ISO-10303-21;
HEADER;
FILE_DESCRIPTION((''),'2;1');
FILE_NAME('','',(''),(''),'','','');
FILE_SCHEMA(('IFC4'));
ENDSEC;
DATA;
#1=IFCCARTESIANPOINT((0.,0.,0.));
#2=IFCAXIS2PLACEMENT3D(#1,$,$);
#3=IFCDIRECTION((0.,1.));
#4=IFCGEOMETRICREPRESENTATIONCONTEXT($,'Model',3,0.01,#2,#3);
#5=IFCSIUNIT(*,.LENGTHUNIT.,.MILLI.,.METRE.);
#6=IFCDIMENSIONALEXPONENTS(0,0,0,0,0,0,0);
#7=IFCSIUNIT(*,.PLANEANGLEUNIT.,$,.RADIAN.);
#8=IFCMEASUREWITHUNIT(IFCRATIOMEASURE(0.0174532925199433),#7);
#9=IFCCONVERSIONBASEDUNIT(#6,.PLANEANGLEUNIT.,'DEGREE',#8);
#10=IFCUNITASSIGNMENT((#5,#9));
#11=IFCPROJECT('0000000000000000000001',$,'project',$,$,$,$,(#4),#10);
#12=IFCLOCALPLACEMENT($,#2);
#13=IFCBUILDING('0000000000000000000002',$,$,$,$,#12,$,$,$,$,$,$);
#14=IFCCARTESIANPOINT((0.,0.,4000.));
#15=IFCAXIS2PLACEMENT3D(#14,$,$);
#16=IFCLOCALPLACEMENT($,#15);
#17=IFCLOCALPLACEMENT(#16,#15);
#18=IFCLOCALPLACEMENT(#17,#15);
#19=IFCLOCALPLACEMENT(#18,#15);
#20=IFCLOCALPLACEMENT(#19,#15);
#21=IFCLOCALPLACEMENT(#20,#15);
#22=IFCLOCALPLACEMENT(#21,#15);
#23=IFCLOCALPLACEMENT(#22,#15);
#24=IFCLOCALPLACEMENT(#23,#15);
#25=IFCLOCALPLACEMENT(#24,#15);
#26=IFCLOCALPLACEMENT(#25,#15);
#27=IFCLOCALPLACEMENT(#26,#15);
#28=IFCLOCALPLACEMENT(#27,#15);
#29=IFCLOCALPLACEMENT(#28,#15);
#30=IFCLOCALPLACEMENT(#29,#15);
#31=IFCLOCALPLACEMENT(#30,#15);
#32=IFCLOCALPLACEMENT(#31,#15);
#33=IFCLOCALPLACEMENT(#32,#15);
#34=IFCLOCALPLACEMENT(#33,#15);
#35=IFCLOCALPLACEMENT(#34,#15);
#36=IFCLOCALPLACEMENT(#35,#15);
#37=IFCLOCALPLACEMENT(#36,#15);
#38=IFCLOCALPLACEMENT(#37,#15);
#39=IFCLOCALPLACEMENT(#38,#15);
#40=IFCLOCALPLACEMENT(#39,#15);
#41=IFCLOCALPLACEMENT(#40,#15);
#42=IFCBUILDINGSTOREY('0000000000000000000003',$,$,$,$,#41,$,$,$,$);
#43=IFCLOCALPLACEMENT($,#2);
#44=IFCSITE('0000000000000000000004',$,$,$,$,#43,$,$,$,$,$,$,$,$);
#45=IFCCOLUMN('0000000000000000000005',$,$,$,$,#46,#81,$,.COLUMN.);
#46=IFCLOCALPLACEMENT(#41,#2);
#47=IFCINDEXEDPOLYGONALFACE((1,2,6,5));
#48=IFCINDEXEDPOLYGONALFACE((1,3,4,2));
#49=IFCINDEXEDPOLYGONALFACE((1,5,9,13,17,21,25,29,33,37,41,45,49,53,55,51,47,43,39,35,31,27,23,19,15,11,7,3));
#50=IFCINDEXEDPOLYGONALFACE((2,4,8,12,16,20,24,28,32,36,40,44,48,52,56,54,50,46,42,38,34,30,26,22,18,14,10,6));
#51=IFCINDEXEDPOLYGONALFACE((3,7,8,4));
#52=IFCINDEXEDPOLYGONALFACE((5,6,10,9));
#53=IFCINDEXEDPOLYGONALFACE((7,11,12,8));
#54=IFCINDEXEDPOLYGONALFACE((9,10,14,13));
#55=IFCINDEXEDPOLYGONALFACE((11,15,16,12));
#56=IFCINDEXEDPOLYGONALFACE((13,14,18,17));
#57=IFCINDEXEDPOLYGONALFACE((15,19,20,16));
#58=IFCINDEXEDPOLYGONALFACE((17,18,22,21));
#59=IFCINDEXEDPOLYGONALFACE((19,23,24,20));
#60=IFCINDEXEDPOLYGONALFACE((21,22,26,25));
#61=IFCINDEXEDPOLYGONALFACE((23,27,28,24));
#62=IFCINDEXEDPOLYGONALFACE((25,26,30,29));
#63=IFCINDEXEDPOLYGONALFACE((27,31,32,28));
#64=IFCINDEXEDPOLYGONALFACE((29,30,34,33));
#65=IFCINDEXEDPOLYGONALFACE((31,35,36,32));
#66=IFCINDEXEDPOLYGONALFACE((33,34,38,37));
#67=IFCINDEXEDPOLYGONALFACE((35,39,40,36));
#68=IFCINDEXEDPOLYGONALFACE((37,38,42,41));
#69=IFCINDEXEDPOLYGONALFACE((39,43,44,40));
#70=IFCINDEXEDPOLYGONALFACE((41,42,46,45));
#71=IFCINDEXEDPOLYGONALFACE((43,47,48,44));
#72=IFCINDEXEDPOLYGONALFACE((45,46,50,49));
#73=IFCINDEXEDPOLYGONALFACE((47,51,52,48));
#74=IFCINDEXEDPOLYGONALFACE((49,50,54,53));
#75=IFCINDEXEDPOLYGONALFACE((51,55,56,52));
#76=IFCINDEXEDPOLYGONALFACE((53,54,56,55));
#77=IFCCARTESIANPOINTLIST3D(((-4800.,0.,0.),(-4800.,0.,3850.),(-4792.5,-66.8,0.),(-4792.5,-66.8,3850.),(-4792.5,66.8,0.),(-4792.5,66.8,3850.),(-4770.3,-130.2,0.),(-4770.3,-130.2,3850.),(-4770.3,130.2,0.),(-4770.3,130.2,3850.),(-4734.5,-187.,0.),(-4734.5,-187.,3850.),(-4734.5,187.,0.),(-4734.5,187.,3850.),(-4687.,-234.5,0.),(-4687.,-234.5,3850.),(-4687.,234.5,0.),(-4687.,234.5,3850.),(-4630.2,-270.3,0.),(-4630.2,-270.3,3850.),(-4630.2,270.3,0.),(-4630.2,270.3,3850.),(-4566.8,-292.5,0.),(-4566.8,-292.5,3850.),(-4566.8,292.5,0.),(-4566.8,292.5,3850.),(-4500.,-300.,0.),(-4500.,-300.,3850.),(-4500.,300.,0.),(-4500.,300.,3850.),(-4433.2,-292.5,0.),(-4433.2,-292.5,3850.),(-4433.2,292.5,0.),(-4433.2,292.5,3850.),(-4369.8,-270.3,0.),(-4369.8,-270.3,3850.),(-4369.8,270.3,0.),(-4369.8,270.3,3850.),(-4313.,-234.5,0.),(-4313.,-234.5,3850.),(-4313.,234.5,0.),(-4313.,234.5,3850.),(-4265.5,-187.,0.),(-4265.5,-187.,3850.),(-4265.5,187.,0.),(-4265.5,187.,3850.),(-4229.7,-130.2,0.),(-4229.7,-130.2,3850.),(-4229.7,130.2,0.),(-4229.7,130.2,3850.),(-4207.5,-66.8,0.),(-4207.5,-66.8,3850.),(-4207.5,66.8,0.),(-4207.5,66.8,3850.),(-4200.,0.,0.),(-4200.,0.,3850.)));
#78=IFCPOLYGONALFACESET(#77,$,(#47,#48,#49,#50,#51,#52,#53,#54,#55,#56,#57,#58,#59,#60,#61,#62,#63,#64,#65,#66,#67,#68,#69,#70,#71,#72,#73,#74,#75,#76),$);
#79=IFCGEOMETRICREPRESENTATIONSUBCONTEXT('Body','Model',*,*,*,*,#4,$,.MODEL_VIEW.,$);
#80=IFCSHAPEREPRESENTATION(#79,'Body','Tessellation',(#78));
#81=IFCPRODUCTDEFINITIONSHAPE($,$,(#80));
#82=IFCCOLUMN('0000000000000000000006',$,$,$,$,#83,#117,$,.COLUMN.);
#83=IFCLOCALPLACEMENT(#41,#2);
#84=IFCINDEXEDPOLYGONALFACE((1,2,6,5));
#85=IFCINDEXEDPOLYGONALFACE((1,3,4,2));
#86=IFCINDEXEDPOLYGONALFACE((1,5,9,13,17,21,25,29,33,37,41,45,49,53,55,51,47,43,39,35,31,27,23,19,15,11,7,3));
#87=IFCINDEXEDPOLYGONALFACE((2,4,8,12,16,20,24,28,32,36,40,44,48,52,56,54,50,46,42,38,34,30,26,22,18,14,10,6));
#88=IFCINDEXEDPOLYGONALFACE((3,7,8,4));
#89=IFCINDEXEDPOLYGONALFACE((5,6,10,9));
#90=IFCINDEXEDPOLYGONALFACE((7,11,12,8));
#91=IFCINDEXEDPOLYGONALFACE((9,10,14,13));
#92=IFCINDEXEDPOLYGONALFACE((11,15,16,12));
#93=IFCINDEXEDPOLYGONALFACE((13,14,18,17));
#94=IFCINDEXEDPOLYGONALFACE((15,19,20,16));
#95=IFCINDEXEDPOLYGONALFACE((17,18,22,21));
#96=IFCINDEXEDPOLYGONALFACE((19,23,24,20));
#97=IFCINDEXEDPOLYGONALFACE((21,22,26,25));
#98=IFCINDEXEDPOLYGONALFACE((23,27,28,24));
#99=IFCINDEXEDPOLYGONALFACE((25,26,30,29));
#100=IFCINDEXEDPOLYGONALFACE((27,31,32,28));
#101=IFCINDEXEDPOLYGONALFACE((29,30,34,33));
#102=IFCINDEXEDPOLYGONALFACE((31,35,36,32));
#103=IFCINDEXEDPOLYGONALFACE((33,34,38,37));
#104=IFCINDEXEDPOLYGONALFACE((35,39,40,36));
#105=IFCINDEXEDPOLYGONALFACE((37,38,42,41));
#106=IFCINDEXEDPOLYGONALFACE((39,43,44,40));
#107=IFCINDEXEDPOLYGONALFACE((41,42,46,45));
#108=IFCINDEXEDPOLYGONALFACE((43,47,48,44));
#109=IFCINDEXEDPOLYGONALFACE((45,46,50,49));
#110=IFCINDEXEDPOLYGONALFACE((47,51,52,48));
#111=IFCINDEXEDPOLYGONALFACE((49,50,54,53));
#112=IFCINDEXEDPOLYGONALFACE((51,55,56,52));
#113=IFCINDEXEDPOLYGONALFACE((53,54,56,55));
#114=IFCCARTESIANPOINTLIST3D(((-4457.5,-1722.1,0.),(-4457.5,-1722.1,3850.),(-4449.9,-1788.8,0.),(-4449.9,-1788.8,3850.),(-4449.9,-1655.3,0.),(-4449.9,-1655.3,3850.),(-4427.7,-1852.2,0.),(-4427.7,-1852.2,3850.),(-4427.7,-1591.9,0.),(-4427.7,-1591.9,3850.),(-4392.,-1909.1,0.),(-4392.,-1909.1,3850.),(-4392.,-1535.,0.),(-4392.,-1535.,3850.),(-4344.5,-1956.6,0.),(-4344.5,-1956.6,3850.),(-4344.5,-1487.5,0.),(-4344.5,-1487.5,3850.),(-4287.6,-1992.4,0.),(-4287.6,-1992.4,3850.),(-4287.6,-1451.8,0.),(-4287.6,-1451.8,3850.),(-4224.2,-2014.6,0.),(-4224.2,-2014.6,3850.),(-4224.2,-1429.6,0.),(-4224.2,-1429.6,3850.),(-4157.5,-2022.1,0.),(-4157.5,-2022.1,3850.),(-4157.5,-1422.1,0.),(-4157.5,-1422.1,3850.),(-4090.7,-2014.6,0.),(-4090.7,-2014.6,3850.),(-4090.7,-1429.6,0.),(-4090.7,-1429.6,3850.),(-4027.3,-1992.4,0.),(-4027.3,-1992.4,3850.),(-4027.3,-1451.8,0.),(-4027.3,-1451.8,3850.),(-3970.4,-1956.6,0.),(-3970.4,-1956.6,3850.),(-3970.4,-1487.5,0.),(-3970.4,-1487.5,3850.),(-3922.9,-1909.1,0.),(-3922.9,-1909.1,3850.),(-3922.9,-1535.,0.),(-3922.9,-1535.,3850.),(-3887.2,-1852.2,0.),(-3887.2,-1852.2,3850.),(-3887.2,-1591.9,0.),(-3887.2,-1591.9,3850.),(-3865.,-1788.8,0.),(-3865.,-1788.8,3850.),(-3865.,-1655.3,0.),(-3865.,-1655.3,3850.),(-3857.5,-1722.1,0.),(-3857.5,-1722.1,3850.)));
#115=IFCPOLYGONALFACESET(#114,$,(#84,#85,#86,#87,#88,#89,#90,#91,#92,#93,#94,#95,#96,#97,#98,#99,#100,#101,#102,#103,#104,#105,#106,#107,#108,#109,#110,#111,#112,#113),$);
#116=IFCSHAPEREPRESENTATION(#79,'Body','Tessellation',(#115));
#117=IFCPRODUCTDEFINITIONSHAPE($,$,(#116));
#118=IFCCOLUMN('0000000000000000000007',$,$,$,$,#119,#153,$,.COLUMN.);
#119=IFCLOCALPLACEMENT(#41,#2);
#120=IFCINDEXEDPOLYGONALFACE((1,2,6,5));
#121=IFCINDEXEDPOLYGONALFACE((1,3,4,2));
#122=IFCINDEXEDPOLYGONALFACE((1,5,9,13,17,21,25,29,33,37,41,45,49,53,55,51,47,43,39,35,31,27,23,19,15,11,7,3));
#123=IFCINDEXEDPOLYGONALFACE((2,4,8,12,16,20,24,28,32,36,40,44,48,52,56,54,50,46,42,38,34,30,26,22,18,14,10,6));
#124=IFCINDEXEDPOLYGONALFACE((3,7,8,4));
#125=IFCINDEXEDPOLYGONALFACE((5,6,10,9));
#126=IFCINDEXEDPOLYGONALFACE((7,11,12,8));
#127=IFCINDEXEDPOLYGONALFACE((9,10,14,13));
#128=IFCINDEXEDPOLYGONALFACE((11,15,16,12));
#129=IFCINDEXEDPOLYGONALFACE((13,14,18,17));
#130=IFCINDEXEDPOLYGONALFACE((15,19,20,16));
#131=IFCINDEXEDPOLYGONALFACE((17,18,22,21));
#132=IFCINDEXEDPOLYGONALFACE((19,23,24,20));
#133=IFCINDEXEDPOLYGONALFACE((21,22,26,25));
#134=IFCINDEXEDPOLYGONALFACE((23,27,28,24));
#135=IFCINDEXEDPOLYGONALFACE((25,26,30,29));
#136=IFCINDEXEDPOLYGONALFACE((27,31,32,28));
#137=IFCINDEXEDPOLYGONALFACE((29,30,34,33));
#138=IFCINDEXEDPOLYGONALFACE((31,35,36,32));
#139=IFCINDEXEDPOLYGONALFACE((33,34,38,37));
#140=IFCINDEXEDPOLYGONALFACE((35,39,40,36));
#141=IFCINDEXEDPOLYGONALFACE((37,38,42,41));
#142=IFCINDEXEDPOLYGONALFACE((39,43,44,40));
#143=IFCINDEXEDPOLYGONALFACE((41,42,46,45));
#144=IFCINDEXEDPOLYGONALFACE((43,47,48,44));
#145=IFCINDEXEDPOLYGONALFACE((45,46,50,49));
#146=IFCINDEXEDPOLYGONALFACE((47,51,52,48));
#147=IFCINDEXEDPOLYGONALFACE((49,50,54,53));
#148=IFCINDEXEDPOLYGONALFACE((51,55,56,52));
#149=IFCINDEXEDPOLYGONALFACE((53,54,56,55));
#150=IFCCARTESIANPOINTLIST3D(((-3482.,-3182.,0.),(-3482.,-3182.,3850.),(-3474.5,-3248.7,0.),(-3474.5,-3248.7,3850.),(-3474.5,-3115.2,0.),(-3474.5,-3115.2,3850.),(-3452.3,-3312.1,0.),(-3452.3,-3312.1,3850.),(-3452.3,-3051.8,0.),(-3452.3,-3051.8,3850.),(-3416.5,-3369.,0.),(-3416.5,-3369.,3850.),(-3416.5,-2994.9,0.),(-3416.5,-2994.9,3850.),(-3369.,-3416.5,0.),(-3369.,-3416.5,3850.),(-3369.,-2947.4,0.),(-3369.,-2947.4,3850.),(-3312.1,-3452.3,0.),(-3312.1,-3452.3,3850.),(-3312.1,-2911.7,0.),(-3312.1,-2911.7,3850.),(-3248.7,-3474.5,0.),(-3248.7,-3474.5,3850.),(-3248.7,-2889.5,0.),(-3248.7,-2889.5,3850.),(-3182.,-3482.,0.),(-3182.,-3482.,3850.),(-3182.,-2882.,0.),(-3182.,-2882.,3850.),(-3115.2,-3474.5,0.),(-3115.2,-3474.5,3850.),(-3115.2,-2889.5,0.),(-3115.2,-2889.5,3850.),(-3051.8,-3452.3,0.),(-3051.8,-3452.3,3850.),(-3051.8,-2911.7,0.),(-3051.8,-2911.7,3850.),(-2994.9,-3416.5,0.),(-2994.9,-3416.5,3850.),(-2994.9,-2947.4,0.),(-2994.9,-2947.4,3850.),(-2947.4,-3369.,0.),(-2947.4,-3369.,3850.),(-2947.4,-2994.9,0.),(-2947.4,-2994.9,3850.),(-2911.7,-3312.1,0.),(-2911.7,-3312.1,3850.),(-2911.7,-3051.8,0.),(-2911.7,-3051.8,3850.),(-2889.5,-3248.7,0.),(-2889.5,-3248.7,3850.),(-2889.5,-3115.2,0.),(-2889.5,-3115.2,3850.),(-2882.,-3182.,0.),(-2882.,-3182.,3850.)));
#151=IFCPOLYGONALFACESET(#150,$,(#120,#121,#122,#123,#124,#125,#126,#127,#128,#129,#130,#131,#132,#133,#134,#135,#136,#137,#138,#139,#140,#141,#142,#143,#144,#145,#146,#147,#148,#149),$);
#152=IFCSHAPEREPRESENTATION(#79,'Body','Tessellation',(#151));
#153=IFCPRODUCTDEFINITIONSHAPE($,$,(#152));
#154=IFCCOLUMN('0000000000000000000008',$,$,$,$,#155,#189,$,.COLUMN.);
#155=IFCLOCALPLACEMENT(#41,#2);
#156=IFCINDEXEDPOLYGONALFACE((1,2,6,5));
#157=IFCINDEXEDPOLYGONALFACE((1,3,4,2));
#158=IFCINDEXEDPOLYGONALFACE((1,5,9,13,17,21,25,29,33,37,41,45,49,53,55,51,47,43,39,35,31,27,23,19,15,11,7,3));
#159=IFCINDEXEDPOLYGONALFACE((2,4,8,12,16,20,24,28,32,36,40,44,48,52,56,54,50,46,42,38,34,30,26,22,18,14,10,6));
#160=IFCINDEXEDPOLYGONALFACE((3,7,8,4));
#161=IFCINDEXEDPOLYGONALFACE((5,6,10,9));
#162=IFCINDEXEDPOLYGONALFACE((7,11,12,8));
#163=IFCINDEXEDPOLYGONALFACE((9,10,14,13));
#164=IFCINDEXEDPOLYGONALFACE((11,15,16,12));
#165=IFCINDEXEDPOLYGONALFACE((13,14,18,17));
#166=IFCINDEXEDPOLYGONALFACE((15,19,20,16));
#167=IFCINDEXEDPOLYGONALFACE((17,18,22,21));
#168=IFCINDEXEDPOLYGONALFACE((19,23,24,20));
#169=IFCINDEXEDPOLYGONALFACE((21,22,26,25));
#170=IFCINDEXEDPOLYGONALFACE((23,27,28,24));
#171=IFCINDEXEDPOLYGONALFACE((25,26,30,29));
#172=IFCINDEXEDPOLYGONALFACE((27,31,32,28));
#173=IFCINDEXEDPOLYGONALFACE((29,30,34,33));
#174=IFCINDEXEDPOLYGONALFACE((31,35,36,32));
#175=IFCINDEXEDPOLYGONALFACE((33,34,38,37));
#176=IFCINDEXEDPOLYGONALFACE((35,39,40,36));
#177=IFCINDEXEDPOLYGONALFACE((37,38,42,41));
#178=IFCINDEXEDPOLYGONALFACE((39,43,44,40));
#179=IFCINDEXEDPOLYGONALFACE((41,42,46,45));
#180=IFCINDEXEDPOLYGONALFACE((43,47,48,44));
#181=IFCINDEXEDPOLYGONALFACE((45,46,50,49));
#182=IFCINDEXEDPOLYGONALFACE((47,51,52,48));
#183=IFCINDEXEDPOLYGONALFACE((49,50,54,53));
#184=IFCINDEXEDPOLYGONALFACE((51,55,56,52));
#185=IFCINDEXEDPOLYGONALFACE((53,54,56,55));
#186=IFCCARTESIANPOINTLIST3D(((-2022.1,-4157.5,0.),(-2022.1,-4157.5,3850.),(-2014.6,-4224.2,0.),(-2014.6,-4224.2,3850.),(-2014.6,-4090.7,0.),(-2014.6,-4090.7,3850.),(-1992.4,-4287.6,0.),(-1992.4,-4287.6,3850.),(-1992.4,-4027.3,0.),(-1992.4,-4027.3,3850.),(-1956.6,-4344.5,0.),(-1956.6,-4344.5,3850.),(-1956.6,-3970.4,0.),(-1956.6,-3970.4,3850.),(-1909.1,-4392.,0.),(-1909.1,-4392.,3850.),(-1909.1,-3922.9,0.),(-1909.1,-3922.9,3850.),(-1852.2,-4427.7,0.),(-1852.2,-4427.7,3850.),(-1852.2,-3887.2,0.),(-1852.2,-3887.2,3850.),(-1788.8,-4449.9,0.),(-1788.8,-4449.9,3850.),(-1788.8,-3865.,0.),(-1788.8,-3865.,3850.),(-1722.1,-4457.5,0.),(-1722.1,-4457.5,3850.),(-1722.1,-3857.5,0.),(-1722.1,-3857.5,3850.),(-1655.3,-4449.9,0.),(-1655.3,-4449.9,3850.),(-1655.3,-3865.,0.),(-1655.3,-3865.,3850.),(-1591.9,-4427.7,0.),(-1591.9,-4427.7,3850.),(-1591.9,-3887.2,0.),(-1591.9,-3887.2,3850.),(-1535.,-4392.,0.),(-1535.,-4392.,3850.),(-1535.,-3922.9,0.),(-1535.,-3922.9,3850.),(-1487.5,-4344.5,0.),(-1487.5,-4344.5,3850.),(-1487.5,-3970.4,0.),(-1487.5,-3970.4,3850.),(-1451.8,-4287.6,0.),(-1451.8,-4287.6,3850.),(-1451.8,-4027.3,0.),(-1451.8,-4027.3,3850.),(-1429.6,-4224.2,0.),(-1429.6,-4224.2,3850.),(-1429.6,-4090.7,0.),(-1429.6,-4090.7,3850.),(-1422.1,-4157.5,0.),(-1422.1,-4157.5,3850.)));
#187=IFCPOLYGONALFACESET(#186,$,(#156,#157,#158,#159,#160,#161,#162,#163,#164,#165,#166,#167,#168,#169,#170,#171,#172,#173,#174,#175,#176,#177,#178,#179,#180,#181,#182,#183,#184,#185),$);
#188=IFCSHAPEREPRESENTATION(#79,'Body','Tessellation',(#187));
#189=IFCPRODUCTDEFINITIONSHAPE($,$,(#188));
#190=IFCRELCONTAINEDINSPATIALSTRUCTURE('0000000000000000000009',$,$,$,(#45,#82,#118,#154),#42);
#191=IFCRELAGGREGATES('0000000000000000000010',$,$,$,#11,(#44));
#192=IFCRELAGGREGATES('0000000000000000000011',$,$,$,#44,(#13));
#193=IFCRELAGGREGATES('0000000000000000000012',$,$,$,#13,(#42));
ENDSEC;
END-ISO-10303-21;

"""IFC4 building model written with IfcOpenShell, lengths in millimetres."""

from ifc_helpers import new_model, entity, si_unit, converted_unit, direction, frame, origin, origin_2d, place, context, subcontext, project, spatial, circle, extrude, element, save


model = new_model("IFC4")

# Units and contexts
model_context = context("Model", 3, precision=0.01, world=origin(), true_north=direction((0.0, 1.0)))
body_context = subcontext(model_context, "Body", "Model", "MODEL_VIEW")
ifc_project = project(units=[si_unit("LENGTHUNIT", "METRE", prefix="MILLI"), converted_unit("PLANEANGLEUNIT", "DEGREE", entity("IfcRatioMeasure", 0.0174532925199433), si_unit("PLANEANGLEUNIT", "RADIAN"), dimensions=[0, 0, 0, 0, 0, 0, 0])], contexts=[model_context])

# Site, building, storey
site_placement = place(None, origin())
site = spatial("IfcSite", under=ifc_project, at=site_placement)
building_placement = place(None, origin())
building = spatial("IfcBuilding", under=site, at=building_placement)
placement_1 = place(None, frame((0.0, 0.0, 4000.0)))
placement_2 = place(placement_1, frame((0.0, 0.0, 4000.0)))
placement_3 = place(placement_2, frame((0.0, 0.0, 4000.0)))
placement_4 = place(placement_3, frame((0.0, 0.0, 4000.0)))
placement_5 = place(placement_4, frame((0.0, 0.0, 4000.0)))
placement_6 = place(placement_5, frame((0.0, 0.0, 4000.0)))
placement_7 = place(placement_6, frame((0.0, 0.0, 4000.0)))
placement_8 = place(placement_7, frame((0.0, 0.0, 4000.0)))
placement_9 = place(placement_8, frame((0.0, 0.0, 4000.0)))
placement_10 = place(placement_9, frame((0.0, 0.0, 4000.0)))
placement_11 = place(placement_10, frame((0.0, 0.0, 4000.0)))
placement_12 = place(placement_11, frame((0.0, 0.0, 4000.0)))
placement_13 = place(placement_12, frame((0.0, 0.0, 4000.0)))
placement_14 = place(placement_13, frame((0.0, 0.0, 4000.0)))
placement_15 = place(placement_14, frame((0.0, 0.0, 4000.0)))
placement_16 = place(placement_15, frame((0.0, 0.0, 4000.0)))
placement_17 = place(placement_16, frame((0.0, 0.0, 4000.0)))
placement_18 = place(placement_17, frame((0.0, 0.0, 4000.0)))
placement_19 = place(placement_18, frame((0.0, 0.0, 4000.0)))
placement_20 = place(placement_19, frame((0.0, 0.0, 4000.0)))
placement_21 = place(placement_20, frame((0.0, 0.0, 4000.0)))
placement_22 = place(placement_21, frame((0.0, 0.0, 4000.0)))
placement_23 = place(placement_22, frame((0.0, 0.0, 4000.0)))
placement_24 = place(placement_23, frame((0.0, 0.0, 4000.0)))
placement_25 = place(placement_24, frame((0.0, 0.0, 4000.0)))
storey_placement = place(placement_25, frame((0.0, 0.0, 4000.0)))
storey = spatial("IfcBuildingStorey", under=building, at=storey_placement)

# Columns
for number, where in (
    (1, (-4500.0, 0.0, 0.0)),
    (2, (-4157.5, -1722.1, 0.0)),
    (3, (-3182.0, -3182.0, 0.0)),
    (4, (-1722.1, -4157.5, 0.0)),
):
    element("IfcColumn", number, at=place(storey_placement, frame(where)), inside=storey, PredefinedType="COLUMN", context=body_context, shape_type="SweptSolid", body=[
        extrude(circle(Radius=300.0, at=origin_2d()), origin(), (0.0, 0.0, 1.0), 3850.0),
    ])

save(model, "model.ifc")
